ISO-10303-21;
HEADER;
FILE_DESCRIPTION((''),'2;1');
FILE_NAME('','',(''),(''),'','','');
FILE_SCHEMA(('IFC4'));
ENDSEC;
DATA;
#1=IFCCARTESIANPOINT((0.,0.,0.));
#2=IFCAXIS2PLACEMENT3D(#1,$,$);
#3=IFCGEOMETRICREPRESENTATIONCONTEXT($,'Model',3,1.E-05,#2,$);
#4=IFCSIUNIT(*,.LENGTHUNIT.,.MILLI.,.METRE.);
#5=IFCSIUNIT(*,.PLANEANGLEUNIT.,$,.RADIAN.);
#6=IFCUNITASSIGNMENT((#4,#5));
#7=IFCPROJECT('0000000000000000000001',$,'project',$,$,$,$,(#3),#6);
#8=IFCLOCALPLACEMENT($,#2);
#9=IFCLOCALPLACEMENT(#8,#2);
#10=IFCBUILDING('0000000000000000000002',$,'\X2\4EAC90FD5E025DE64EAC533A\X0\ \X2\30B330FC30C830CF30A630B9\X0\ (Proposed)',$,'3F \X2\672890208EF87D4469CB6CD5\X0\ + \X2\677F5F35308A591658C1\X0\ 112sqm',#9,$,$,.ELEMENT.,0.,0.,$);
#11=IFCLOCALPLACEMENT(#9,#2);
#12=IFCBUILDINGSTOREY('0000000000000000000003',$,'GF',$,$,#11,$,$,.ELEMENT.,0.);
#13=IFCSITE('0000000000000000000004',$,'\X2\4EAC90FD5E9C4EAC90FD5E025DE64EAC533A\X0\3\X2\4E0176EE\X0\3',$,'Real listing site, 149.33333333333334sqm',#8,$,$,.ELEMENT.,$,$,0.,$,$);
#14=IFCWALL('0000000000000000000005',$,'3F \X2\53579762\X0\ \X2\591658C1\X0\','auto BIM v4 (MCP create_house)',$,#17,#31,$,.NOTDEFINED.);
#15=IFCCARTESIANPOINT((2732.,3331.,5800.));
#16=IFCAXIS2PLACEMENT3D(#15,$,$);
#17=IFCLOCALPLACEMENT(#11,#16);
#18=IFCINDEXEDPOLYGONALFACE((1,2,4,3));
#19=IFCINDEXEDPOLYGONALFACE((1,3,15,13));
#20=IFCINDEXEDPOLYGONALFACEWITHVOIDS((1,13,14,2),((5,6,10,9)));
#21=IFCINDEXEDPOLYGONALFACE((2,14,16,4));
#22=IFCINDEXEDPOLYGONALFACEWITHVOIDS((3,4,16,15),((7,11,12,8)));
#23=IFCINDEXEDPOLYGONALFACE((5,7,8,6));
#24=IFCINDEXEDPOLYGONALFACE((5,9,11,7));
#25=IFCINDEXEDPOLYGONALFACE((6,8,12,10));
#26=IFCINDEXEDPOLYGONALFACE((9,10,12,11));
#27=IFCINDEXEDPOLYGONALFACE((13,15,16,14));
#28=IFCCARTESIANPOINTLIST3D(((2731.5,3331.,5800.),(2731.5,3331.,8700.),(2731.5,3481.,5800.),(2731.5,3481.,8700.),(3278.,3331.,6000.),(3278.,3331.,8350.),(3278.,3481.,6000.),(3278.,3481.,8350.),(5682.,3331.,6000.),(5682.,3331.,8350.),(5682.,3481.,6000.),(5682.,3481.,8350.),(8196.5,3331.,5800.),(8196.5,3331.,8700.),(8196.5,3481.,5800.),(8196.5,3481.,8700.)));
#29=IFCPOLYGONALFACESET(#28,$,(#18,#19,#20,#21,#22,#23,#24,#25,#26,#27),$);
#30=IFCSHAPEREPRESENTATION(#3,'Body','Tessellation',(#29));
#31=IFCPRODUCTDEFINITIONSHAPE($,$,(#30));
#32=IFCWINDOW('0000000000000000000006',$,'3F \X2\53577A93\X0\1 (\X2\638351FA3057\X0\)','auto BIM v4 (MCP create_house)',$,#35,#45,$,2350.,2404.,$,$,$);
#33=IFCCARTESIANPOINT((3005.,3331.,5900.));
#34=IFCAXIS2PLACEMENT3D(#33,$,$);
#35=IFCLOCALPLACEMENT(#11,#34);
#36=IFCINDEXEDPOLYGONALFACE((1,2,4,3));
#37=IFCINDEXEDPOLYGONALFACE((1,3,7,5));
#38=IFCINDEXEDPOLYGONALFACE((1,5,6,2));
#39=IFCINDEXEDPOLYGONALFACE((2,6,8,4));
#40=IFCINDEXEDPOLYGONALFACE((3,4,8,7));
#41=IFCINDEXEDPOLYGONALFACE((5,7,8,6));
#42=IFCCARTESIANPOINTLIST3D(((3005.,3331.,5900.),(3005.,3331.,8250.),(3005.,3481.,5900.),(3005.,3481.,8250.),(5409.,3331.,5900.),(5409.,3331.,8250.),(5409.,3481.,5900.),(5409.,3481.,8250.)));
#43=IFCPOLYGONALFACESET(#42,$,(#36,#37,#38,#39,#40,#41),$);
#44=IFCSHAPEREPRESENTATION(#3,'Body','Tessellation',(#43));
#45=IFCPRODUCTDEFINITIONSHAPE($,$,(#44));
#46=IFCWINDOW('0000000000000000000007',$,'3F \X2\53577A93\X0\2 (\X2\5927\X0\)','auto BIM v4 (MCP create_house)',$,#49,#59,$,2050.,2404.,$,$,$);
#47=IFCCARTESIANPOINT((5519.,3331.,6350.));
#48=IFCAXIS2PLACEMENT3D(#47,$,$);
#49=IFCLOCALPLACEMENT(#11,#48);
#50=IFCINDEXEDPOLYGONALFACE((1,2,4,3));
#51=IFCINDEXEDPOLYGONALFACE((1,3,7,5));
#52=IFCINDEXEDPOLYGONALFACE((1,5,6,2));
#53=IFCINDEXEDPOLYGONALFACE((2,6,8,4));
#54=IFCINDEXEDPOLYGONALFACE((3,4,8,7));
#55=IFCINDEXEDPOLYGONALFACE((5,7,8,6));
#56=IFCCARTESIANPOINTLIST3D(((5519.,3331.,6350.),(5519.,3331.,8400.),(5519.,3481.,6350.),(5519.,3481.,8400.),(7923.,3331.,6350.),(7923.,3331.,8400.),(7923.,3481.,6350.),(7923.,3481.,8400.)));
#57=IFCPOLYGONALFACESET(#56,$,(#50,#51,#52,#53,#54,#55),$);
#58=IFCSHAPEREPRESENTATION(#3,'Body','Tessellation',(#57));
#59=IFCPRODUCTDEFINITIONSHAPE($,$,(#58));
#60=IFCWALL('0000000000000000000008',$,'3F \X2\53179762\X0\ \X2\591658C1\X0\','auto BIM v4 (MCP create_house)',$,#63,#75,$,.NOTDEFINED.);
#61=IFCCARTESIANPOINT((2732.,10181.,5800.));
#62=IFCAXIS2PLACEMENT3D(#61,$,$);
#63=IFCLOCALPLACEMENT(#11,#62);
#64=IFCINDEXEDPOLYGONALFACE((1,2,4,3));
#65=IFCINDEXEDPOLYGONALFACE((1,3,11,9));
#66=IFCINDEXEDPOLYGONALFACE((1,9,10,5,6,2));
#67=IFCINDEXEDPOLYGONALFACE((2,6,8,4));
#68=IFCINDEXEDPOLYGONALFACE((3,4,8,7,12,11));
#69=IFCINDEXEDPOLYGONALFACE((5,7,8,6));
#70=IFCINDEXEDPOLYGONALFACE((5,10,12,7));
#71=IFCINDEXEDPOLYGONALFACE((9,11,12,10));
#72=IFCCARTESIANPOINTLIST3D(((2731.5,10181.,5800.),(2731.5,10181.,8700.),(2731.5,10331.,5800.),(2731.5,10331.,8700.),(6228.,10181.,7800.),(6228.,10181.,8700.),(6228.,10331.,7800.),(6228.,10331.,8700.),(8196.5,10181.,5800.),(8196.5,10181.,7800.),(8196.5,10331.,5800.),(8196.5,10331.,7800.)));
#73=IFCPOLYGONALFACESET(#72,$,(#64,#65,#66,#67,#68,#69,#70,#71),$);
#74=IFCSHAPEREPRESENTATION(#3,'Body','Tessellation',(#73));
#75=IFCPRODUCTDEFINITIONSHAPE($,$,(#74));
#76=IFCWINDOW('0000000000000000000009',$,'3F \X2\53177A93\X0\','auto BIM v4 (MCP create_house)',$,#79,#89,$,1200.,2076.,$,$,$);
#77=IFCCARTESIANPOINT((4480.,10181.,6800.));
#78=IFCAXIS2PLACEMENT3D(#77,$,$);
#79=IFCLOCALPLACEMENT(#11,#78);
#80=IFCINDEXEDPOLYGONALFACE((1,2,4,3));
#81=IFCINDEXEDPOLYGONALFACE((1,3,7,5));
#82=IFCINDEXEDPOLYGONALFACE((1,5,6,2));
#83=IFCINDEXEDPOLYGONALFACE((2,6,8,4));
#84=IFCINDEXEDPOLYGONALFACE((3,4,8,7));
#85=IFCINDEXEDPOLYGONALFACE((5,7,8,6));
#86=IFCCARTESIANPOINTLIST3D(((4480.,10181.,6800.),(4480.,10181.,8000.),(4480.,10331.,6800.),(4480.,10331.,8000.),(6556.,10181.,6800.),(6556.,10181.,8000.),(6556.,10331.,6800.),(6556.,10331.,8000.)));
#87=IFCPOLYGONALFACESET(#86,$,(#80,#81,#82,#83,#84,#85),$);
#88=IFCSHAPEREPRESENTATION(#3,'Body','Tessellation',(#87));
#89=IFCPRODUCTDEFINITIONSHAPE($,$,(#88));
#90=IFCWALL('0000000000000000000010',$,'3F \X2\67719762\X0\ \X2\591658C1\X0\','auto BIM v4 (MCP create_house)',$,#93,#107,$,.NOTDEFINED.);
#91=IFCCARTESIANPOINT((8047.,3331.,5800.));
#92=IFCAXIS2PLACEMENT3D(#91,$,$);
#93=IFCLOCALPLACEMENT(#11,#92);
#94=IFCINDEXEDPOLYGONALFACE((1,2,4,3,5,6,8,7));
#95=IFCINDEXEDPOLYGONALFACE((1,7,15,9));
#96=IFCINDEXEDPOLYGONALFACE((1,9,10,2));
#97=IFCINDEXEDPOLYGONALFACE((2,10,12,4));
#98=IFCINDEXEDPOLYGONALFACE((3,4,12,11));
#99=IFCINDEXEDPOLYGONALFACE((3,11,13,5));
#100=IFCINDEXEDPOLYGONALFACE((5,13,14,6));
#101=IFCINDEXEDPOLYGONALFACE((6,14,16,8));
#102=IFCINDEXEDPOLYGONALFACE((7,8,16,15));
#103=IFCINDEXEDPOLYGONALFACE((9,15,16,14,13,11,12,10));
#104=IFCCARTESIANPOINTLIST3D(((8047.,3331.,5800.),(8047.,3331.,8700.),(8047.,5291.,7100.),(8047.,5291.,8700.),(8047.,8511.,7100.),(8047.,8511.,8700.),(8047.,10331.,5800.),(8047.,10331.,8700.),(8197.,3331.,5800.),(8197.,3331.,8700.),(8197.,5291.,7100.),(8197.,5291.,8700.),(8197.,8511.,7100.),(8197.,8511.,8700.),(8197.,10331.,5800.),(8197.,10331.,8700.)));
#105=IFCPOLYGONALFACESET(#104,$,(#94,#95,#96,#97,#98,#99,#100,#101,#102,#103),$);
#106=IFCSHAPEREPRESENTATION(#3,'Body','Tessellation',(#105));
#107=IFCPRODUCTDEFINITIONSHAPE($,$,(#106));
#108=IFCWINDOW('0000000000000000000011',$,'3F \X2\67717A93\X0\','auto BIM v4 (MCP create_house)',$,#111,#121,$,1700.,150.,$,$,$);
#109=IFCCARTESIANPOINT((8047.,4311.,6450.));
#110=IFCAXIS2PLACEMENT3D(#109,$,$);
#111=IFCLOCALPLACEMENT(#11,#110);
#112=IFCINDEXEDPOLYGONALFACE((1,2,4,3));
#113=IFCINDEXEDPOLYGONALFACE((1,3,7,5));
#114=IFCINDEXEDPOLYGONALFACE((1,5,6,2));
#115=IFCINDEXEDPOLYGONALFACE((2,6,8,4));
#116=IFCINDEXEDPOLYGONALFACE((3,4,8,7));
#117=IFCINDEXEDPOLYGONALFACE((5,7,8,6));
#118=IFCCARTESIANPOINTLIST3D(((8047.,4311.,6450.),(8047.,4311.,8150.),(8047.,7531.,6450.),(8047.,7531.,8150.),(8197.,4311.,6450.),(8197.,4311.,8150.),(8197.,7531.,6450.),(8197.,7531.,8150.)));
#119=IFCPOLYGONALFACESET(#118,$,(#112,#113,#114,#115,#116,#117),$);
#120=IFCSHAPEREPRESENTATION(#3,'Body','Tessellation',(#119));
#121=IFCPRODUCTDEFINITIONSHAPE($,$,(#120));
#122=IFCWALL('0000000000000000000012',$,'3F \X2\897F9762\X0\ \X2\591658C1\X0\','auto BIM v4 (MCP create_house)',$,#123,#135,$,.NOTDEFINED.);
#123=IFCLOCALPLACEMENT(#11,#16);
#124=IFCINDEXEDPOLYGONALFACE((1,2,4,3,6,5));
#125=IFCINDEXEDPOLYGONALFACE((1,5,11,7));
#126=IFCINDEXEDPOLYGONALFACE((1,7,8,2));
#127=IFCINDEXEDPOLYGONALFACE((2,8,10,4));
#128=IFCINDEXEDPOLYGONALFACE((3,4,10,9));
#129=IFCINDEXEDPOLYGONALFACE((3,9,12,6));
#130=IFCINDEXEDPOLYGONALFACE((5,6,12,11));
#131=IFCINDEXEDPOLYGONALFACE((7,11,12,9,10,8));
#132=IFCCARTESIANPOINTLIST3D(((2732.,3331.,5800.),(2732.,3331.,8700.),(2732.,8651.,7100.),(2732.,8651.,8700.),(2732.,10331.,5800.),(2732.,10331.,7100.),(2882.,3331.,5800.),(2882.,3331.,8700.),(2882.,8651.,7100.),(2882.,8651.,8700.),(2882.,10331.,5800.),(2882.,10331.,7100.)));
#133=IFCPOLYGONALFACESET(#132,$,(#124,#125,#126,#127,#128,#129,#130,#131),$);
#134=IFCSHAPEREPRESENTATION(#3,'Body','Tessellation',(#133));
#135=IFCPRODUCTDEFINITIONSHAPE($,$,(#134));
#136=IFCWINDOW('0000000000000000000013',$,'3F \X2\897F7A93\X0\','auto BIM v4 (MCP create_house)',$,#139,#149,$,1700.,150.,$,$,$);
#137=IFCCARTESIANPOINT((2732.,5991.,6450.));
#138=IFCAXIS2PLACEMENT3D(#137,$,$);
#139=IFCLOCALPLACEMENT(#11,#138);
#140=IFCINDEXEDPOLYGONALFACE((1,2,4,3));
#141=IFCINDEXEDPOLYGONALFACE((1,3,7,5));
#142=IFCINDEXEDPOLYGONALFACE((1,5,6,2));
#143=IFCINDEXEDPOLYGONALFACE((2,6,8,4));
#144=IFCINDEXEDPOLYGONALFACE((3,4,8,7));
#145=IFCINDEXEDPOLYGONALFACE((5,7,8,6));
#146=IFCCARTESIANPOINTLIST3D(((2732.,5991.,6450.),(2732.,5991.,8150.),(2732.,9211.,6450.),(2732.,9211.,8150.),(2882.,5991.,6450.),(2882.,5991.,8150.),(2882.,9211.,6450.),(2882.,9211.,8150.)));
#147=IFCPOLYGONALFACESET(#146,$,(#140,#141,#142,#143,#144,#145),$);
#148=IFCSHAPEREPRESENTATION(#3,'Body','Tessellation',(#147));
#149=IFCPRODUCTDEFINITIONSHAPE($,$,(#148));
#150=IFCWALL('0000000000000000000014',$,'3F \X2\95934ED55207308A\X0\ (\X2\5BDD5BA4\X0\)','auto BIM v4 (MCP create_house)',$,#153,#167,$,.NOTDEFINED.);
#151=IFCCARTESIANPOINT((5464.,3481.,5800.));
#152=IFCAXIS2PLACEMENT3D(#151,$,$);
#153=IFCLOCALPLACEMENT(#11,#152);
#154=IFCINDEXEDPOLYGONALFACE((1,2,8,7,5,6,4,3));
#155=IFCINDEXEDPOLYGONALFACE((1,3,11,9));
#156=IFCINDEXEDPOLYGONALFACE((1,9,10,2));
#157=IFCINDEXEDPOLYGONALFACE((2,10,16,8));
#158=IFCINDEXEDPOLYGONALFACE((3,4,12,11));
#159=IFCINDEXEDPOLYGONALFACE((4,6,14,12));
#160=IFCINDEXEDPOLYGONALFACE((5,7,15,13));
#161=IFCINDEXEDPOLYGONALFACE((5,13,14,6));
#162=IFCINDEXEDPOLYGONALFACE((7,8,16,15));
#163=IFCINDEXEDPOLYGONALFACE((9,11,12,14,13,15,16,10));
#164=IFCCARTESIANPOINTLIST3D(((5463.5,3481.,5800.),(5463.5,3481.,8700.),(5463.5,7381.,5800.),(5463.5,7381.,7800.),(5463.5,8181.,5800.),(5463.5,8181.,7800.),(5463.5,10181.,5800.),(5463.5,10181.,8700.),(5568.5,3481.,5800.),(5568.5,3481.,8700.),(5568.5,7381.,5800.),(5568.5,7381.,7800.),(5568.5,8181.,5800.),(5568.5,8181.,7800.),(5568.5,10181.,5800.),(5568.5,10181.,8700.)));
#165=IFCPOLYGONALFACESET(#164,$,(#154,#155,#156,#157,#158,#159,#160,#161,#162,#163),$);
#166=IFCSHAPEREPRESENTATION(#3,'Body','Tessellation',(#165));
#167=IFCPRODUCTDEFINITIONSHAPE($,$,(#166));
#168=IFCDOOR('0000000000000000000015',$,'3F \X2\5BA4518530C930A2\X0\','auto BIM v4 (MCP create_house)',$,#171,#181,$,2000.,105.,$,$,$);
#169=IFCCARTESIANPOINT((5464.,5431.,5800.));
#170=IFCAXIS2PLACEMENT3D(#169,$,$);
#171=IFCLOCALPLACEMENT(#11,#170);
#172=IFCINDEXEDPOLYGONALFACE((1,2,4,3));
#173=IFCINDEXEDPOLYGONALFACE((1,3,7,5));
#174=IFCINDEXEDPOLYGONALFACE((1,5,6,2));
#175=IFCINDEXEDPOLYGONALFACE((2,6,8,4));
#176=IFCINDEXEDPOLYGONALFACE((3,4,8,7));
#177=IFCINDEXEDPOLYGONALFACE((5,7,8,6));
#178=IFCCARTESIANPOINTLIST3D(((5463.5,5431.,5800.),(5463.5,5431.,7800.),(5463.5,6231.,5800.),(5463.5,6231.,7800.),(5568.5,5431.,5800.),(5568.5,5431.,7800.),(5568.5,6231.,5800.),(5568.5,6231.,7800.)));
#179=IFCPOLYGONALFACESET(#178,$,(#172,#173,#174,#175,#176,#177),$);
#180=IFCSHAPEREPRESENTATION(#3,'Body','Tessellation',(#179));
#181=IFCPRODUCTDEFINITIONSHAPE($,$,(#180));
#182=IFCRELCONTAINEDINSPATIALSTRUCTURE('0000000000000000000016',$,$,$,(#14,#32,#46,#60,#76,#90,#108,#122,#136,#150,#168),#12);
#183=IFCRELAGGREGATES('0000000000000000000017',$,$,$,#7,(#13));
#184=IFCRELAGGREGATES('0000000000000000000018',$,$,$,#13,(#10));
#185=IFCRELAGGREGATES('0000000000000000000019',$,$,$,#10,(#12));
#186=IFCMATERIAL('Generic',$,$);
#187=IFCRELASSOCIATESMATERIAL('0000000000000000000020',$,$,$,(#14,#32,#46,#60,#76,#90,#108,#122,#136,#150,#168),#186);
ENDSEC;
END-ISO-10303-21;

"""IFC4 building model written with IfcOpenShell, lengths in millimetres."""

from ifc_helpers import new_model, si_unit, frame, frame_2d, origin, place, context, project, spatial, rectangle, extrude, material, element, fill, save


model = new_model("IFC4")

# Units and contexts
model_context = context("Model", 3, precision=1e-05, world=origin())
ifc_project = project(units=[si_unit("LENGTHUNIT", "METRE", prefix="MILLI"), si_unit("PLANEANGLEUNIT", "RADIAN")], contexts=[model_context])

# Site, building, storey
site_placement = place(None, origin())
site = spatial("IfcSite", under=ifc_project, at=site_placement, Name="京都府京都市左京区3丁目3", ObjectType="Real listing site, 149.33333333333334sqm", CompositionType="ELEMENT", RefElevation=0.0)
building_placement = place(site_placement, origin())
building = spatial("IfcBuilding", under=site, at=building_placement, Name="京都市左京区 コートハウス (Proposed)", ObjectType="3F 木造軸組構法 + 板張り外壁 112sqm", CompositionType="ELEMENT", ElevationOfRefHeight=0.0, ElevationOfTerrain=0.0)
storey_placement = place(building_placement, origin())
storey = spatial("IfcBuildingStorey", under=building, at=storey_placement, Name="GF", CompositionType="ELEMENT", Elevation=0.0)

# Shared definitions
ifc_material = material(Name="Generic")

# Wall, openings, windows
wall_1_placement = place(storey_placement, frame((2732.0, 3331.0, 5800.0)))
wall_1 = element("IfcWall", 1, at=wall_1_placement, inside=storey, material=ifc_material, Name="3F 南面 外壁", Description="auto BIM v4 (MCP create_house)", PredefinedType="NOTDEFINED", context=model_context, shape_type="SweptSolid", body=[
    extrude(rectangle(XDim=5465.0, YDim=150.0, at=frame_2d((2732.0, 75.0))), frame((2732.0, 3331.0, 5800.0)), (0.0, 0.0, 1.0), 2900.0),
])
opening_1_placement = place(storey_placement, frame((3005.0, 3331.0, 5900.0)))
opening_1 = element("IfcOpeningElement", 2, at=opening_1_placement, cuts=wall_1, PredefinedType="NOTDEFINED", context=model_context, shape_type="SweptSolid", body=[
    extrude(rectangle(XDim=2404.0, YDim=150.0, at=frame_2d((1202.0, 75.0))), frame((3005.0, 3331.0, 5900.0)), (0.0, 0.0, 1.0), 2350.0),
])
opening_2_placement = place(storey_placement, frame((5519.0, 3331.0, 6350.0)))
opening_2 = element("IfcOpeningElement", 3, at=opening_2_placement, cuts=wall_1, PredefinedType="NOTDEFINED", context=model_context, shape_type="SweptSolid", body=[
    extrude(rectangle(XDim=2404.0, YDim=150.0, at=frame_2d((1202.0, 75.0))), frame((5519.0, 3331.0, 6350.0)), (0.0, 0.0, 1.0), 2050.0),
])
window_1_placement = place(storey_placement, frame((3005.0, 3331.0, 5900.0)))
window_1 = element("IfcWindow", 4, at=window_1_placement, inside=storey, material=ifc_material, Name="3F 南窓1 (掃出し)", Description="auto BIM v4 (MCP create_house)", OverallHeight=2350.0, OverallWidth=2404.0, context=model_context, shape_type="SweptSolid", body=[
    extrude(rectangle(XDim=2404.0, YDim=150.0, at=frame_2d((1202.0, 75.0))), frame((3005.0, 3331.0, 5900.0)), (0.0, 0.0, 1.0), 2350.0),
])
fill(opening_1, window_1)
window_2_placement = place(storey_placement, frame((5519.0, 3331.0, 6350.0)))
window_2 = element("IfcWindow", 5, at=window_2_placement, inside=storey, material=ifc_material, Name="3F 南窓2 (大)", Description="auto BIM v4 (MCP create_house)", OverallHeight=2050.0, OverallWidth=2404.0, context=model_context, shape_type="SweptSolid", body=[
    extrude(rectangle(XDim=2404.0, YDim=150.0, at=frame_2d((1202.0, 75.0))), frame((5519.0, 3331.0, 6350.0)), (0.0, 0.0, 1.0), 2050.0),
])
fill(opening_2, window_2)

# Walls, openings, windows
wall_2_placement = place(storey_placement, frame((2732.0, 10181.0, 5800.0)))
wall_2 = element("IfcWall", 6, at=wall_2_placement, inside=storey, material=ifc_material, Name="3F 北面 外壁", Description="auto BIM v4 (MCP create_house)", PredefinedType="NOTDEFINED", context=model_context, shape_type="SweptSolid", body=[
    extrude(rectangle(XDim=5465.0, YDim=150.0, at=frame_2d((2732.0, 75.0))), frame((2732.0, 10181.0, 5800.0)), (0.0, 0.0, 1.0), 2900.0),
])
opening_3_placement = place(storey_placement, frame((4480.0, 10181.0, 6800.0)))
opening_3 = element("IfcOpeningElement", 7, at=opening_3_placement, cuts=wall_2, PredefinedType="NOTDEFINED", context=model_context, shape_type="SweptSolid", body=[
    extrude(rectangle(XDim=2076.0, YDim=150.0, at=frame_2d((1038.0, 75.0))), frame((4480.0, 10181.0, 6800.0)), (0.0, 0.0, 1.0), 1200.0),
])
window_3_placement = place(storey_placement, frame((4480.0, 10181.0, 6800.0)))
window_3 = element("IfcWindow", 8, at=window_3_placement, inside=storey, material=ifc_material, Name="3F 北窓", Description="auto BIM v4 (MCP create_house)", OverallHeight=1200.0, OverallWidth=2076.0, context=model_context, shape_type="SweptSolid", body=[
    extrude(rectangle(XDim=2076.0, YDim=150.0, at=frame_2d((1038.0, 75.0))), frame((4480.0, 10181.0, 6800.0)), (0.0, 0.0, 1.0), 1200.0),
])
fill(opening_3, window_3)
wall_3_placement = place(storey_placement, frame((8047.0, 3331.0, 5800.0)))
wall_3 = element("IfcWall", 9, at=wall_3_placement, inside=storey, material=ifc_material, Name="3F 東面 外壁", Description="auto BIM v4 (MCP create_house)", PredefinedType="NOTDEFINED", context=model_context, shape_type="SweptSolid", body=[
    extrude(rectangle(XDim=150.0, YDim=7000.0, at=frame_2d((75.0, 3500.0))), frame((8047.0, 3331.0, 5800.0)), (0.0, 0.0, 1.0), 2900.0),
])
opening_4_placement = place(storey_placement, frame((8047.0, 4311.0, 6450.0)))
opening_4 = element("IfcOpeningElement", 10, at=opening_4_placement, cuts=wall_3, PredefinedType="NOTDEFINED", context=model_context, shape_type="SweptSolid", body=[
    extrude(rectangle(XDim=150.0, YDim=3220.0, at=frame_2d((75.0, 1610.0))), frame((8047.0, 4311.0, 6450.0)), (0.0, 0.0, 1.0), 1700.0),
])
window_4_placement = place(storey_placement, frame((8047.0, 4311.0, 6450.0)))
window_4 = element("IfcWindow", 11, at=window_4_placement, inside=storey, material=ifc_material, Name="3F 東窓", Description="auto BIM v4 (MCP create_house)", OverallHeight=1700.0, OverallWidth=150.0, context=model_context, shape_type="SweptSolid", body=[
    extrude(rectangle(XDim=150.0, YDim=3220.0, at=frame_2d((75.0, 1610.0))), frame((8047.0, 4311.0, 6450.0)), (0.0, 0.0, 1.0), 1700.0),
])
fill(opening_4, window_4)
wall_4_placement = place(storey_placement, frame((2732.0, 3331.0, 5800.0)))
wall_4 = element("IfcWall", 12, at=wall_4_placement, inside=storey, material=ifc_material, Name="3F 西面 外壁", Description="auto BIM v4 (MCP create_house)", PredefinedType="NOTDEFINED", context=model_context, shape_type="SweptSolid", body=[
    extrude(rectangle(XDim=150.0, YDim=7000.0, at=frame_2d((75.0, 3500.0))), frame((2732.0, 3331.0, 5800.0)), (0.0, 0.0, 1.0), 2900.0),
])
opening_5_placement = place(storey_placement, frame((2732.0, 5991.0, 6450.0)))
opening_5 = element("IfcOpeningElement", 13, at=opening_5_placement, cuts=wall_4, PredefinedType="NOTDEFINED", context=model_context, shape_type="SweptSolid", body=[
    extrude(rectangle(XDim=150.0, YDim=3220.0, at=frame_2d((75.0, 1610.0))), frame((2732.0, 5991.0, 6450.0)), (0.0, 0.0, 1.0), 1700.0),
])
window_5_placement = place(storey_placement, frame((2732.0, 5991.0, 6450.0)))
window_5 = element("IfcWindow", 14, at=window_5_placement, inside=storey, material=ifc_material, Name="3F 西窓", Description="auto BIM v4 (MCP create_house)", OverallHeight=1700.0, OverallWidth=150.0, context=model_context, shape_type="SweptSolid", body=[
    extrude(rectangle(XDim=150.0, YDim=3220.0, at=frame_2d((75.0, 1610.0))), frame((2732.0, 5991.0, 6450.0)), (0.0, 0.0, 1.0), 1700.0),
])
fill(opening_5, window_5)

# Wall, opening, door
wall_5_placement = place(storey_placement, frame((5464.0, 3481.0, 5800.0)))
wall_5 = element("IfcWall", 15, at=wall_5_placement, inside=storey, material=ifc_material, Name="3F 間仕切り (寝室)", Description="auto BIM v4 (MCP create_house)", PredefinedType="NOTDEFINED", context=model_context, shape_type="SweptSolid", body=[
    extrude(rectangle(XDim=105.0, YDim=6700.0, at=frame_2d((52.0, 3350.0))), frame((5464.0, 3481.0, 5800.0)), (0.0, 0.0, 1.0), 2900.0),
])
opening_6_placement = place(storey_placement, frame((5464.0, 5431.0, 5800.0)))
opening_6 = element("IfcOpeningElement", 16, at=opening_6_placement, cuts=wall_5, PredefinedType="NOTDEFINED", context=model_context, shape_type="SweptSolid", body=[
    extrude(rectangle(XDim=105.0, YDim=800.0, at=frame_2d((52.0, 400.0))), frame((5464.0, 5431.0, 5800.0)), (0.0, 0.0, 1.0), 2000.0),
])
door_1_placement = place(storey_placement, frame((5464.0, 5431.0, 5800.0)))
door_1 = element("IfcDoor", 17, at=door_1_placement, inside=storey, material=ifc_material, Name="3F 室内ドア", Description="auto BIM v4 (MCP create_house)", OverallHeight=2000.0, OverallWidth=105.0, context=model_context, shape_type="SweptSolid", body=[
    extrude(rectangle(XDim=105.0, YDim=800.0, at=frame_2d((52.0, 400.0))), frame((5464.0, 5431.0, 5800.0)), (0.0, 0.0, 1.0), 2000.0),
])
fill(opening_6, door_1)

save(model, "model.ifc")
